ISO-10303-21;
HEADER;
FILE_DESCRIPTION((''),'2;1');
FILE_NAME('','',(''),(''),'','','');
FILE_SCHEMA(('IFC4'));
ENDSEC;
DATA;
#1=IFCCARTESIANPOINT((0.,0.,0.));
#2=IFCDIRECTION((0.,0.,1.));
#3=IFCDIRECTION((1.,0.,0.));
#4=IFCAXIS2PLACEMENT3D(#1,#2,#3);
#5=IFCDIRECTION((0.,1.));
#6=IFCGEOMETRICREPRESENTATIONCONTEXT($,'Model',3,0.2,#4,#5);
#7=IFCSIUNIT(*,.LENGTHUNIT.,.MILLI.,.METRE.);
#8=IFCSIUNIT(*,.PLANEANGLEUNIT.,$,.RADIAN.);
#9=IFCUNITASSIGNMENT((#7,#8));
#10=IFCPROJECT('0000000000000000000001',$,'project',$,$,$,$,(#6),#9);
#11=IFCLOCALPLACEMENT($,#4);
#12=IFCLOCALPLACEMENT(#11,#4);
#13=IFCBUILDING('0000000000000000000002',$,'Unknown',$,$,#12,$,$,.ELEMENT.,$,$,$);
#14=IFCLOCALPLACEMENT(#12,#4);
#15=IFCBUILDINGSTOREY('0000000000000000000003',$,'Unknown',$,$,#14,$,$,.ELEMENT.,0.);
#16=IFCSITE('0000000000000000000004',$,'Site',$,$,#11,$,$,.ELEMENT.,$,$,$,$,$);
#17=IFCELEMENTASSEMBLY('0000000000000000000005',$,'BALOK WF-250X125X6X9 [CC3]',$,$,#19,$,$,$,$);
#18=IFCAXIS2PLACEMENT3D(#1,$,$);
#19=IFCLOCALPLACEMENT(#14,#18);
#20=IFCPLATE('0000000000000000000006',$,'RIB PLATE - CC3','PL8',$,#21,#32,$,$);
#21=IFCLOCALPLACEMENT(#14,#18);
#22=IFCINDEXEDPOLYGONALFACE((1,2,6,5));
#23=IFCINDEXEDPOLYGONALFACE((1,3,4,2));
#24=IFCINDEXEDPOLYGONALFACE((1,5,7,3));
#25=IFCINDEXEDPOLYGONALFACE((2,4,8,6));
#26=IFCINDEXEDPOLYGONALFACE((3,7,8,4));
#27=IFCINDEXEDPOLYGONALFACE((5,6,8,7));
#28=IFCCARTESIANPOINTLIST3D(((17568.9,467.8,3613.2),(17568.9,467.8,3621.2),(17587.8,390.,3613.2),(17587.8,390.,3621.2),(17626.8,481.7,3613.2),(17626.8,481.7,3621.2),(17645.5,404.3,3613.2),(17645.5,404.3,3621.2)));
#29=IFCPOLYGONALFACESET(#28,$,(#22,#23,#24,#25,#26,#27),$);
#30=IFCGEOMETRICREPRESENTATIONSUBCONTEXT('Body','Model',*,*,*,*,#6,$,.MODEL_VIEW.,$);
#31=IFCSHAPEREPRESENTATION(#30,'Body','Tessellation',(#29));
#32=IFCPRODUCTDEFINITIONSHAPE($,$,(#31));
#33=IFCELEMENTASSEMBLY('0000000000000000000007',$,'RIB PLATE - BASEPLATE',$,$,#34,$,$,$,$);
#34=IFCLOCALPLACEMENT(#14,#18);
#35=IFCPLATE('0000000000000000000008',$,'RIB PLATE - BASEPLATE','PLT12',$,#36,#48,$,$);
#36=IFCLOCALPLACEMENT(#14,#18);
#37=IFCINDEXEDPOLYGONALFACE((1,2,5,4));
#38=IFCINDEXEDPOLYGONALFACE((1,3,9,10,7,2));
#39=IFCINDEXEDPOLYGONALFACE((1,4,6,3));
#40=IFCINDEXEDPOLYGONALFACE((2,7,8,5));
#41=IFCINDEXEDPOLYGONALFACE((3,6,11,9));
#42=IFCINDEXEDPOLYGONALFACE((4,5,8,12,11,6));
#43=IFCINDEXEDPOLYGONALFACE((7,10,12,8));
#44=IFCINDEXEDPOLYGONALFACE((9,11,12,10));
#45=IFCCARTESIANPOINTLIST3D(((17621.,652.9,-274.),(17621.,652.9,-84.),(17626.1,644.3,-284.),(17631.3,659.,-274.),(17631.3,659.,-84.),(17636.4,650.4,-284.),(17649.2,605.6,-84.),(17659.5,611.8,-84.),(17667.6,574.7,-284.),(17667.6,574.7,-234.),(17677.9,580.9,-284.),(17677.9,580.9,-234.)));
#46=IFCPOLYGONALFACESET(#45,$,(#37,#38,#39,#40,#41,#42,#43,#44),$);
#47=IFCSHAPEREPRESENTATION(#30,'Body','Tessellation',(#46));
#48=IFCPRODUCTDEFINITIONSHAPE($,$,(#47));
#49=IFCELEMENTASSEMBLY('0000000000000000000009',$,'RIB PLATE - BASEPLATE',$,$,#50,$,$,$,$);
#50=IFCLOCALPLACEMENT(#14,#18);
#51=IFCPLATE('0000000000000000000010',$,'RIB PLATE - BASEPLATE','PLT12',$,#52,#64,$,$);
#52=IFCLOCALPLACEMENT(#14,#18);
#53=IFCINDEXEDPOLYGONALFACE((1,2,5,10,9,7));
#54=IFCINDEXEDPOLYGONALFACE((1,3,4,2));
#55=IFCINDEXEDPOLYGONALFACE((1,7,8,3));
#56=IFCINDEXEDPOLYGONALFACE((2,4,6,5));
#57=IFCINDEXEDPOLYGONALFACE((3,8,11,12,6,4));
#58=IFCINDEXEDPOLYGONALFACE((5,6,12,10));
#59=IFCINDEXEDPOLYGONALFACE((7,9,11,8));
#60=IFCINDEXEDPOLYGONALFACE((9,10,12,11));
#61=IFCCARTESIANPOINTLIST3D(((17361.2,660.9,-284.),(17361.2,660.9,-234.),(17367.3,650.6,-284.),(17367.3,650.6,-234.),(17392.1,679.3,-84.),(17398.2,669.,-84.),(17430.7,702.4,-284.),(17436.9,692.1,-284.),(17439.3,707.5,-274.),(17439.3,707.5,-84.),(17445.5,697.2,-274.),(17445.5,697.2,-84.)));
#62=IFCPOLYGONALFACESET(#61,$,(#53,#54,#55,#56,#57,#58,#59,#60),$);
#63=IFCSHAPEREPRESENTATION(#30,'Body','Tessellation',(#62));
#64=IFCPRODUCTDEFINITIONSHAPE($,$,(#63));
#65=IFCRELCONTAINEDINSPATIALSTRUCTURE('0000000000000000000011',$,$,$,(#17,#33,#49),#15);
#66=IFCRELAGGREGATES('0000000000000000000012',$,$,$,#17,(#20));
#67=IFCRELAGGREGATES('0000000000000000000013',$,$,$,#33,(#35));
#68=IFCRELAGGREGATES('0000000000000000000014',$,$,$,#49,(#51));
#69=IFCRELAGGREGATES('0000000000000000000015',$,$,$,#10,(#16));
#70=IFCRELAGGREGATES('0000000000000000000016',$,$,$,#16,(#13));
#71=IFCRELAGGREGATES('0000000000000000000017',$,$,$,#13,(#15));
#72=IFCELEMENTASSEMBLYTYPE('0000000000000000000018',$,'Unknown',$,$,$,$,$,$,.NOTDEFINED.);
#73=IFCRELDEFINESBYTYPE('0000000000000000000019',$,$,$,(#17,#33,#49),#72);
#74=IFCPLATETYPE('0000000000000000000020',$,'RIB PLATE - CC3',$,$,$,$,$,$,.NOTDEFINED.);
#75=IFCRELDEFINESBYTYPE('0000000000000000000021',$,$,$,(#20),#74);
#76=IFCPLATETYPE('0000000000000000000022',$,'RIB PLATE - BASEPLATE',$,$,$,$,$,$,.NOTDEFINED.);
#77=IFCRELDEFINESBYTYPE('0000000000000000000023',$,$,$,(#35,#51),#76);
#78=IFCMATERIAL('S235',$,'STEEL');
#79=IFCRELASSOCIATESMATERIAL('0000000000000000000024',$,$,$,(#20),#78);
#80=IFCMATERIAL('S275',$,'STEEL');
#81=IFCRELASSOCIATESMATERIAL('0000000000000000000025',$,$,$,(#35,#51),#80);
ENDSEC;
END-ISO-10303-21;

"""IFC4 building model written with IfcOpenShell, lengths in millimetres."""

from ifc_helpers import new_model, si_unit, direction, frame, origin_with_axes, place, context, subcontext, project, spatial, line, indexed_curve, outline, extrude, material, material_profile, profile_set, profile_usage, type_object, element, aggregate, save


model = new_model("IFC4")

# Units and contexts
model_context = context("Model", 3, precision=0.2, world=origin_with_axes(), true_north=direction((0.0, 1.0)))
body_context = subcontext(model_context, "Body", "Model", "MODEL_VIEW")
ifc_project = project(units=[si_unit("LENGTHUNIT", "METRE", prefix="MILLI"), si_unit("PLANEANGLEUNIT", "RADIAN")], contexts=[model_context])

# Site, building, storey
site_placement = place(None, origin_with_axes())
site = spatial("IfcSite", under=ifc_project, at=site_placement, Name="Site", CompositionType="ELEMENT")
building_placement = place(site_placement, origin_with_axes())
building = spatial("IfcBuilding", under=site, at=building_placement, Name="Unknown", CompositionType="ELEMENT")
storey_placement = place(building_placement, origin_with_axes())
storey = spatial("IfcBuildingStorey", under=building, at=storey_placement, Name="Unknown", CompositionType="ELEMENT", Elevation=0.0)

# Element assembly
element_assembly_type = type_object("IfcElementAssemblyType", Name="Unknown", PredefinedType="NOTDEFINED")
assembly_1_placement = place(storey_placement, frame((17628.6, 487.2, 3619.2), z_axis=(-0.972076, -0.234666, 0.0), x_axis=(0.234666, -0.972076, 0.0)))
assembly_1 = element("IfcElementAssembly", 1, at=assembly_1_placement, inside=storey, type_object=element_assembly_type, Name="BALOK WF-250X125X6X9 [CC3]")
ifc_material_1 = material(Name="S275", Category="STEEL")

# Plate
ifc_material_2 = material(Name="S235", Category="STEEL")
ifc_material_profile_1 = material_profile(ifc_material_2, outline(indexed_curve([(0.0, 0.0), (80.0, 0.0), (79.8, 59.5), (0.1, 59.6)], segments=[line(1, 2, 3, 4, 1)])), Name="PL8")
ifc_profile_set_1 = profile_set([ifc_material_profile_1])
ifc_profile_usage_1 = profile_usage(ifc_profile_set_1, cardinal=5)
plate_type_1 = type_object("IfcPlateType", Name="RIB PLATE - CC3", PredefinedType="NOTDEFINED")
plate_1_placement = place(assembly_1_placement, frame((4.9, -2.0, 62.6), z_axis=(0.0, 1.0, 0.0), x_axis=(0.999999, 0.0, -0.001595)))
plate_1 = element("IfcPlate", 2, at=plate_1_placement, type_object=plate_type_1, material=ifc_profile_usage_1, Name="RIB PLATE - CC3", Description="PL8", context=body_context, shape_type="SolidModel", body=[
    extrude(outline(indexed_curve([(0.0, 0.0), (80.0, 0.0), (79.8, 59.5), (0.1, 59.6)], segments=[line(1, 2, 3, 4, 1)])), frame((0.0, 0.0, 4.0), z_axis=(0.0, 0.0, 1.0), x_axis=(1.0, 0.0, 0.0)), (0.0, 0.0, -1.0), 8.0),
])
aggregate(assembly_1, [plate_1])

# Element assemblies, plates
assembly_2_placement = place(storey_placement, frame((17672.8, 577.8, -284.0), z_axis=(0.858733, 0.512423, 0.0), x_axis=(-0.512423, 0.858733, 0.0)))
assembly_2 = element("IfcElementAssembly", 3, at=assembly_2_placement, inside=storey, type_object=element_assembly_type, Name="RIB PLATE - BASEPLATE")
ifc_material_profile_2 = material_profile(ifc_material_1, outline(indexed_curve([(0.0, 0.0), (81.0, 0.0), (91.0, 10.0), (91.0, 200.0), (36.0, 200.0), (0.0, 50.0)], segments=[line(1, 2, 3, 4, 5, 6, 1)])), Name="PLT12")
ifc_profile_set_2 = profile_set([ifc_material_profile_2])
ifc_profile_usage_2 = profile_usage(ifc_profile_set_2, cardinal=5)
plate_type_2 = type_object("IfcPlateType", Name="RIB PLATE - BASEPLATE", PredefinedType="NOTDEFINED")
plate_2_placement = place(assembly_2_placement, origin_with_axes())
plate_2 = element("IfcPlate", 4, at=plate_2_placement, type_object=plate_type_2, material=ifc_profile_usage_2, Name="RIB PLATE - BASEPLATE", Description="PLT12", context=body_context, shape_type="SolidModel", body=[
    extrude(outline(indexed_curve([(0.0, 0.0), (81.0, 0.0), (91.0, 10.0), (91.0, 200.0), (36.0, 200.0), (0.0, 50.0)], segments=[line(1, 2, 3, 4, 5, 6, 1)])), frame((0.0, 0.0, 6.0), z_axis=(0.0, 0.0, 1.0), x_axis=(1.0, 0.0, 0.0)), (0.0, 0.0, -1.0), 12.0),
])
aggregate(assembly_2, [plate_2])
assembly_3_placement = place(storey_placement, frame((17364.2, 655.7, -284.0), z_axis=(0.512423, -0.858733, 0.0), x_axis=(0.858733, 0.512423, 0.0)))
assembly_3 = element("IfcElementAssembly", 5, at=assembly_3_placement, inside=storey, type_object=element_assembly_type, Name="RIB PLATE - BASEPLATE")
plate_3_placement = place(assembly_3_placement, origin_with_axes())
plate_3 = element("IfcPlate", 6, at=plate_3_placement, type_object=plate_type_2, material=ifc_profile_usage_2, Name="RIB PLATE - BASEPLATE", Description="PLT12", context=body_context, shape_type="SolidModel", body=[
    extrude(outline(indexed_curve([(0.0, 0.0), (81.0, 0.0), (91.0, 10.0), (91.0, 200.0), (36.0, 200.0), (0.0, 50.0)], segments=[line(1, 2, 3, 4, 5, 6, 1)])), frame((0.0, 0.0, 6.0), z_axis=(0.0, 0.0, 1.0), x_axis=(1.0, 0.0, 0.0)), (0.0, 0.0, -1.0), 12.0),
])
aggregate(assembly_3, [plate_3])

save(model, "model.ifc")
